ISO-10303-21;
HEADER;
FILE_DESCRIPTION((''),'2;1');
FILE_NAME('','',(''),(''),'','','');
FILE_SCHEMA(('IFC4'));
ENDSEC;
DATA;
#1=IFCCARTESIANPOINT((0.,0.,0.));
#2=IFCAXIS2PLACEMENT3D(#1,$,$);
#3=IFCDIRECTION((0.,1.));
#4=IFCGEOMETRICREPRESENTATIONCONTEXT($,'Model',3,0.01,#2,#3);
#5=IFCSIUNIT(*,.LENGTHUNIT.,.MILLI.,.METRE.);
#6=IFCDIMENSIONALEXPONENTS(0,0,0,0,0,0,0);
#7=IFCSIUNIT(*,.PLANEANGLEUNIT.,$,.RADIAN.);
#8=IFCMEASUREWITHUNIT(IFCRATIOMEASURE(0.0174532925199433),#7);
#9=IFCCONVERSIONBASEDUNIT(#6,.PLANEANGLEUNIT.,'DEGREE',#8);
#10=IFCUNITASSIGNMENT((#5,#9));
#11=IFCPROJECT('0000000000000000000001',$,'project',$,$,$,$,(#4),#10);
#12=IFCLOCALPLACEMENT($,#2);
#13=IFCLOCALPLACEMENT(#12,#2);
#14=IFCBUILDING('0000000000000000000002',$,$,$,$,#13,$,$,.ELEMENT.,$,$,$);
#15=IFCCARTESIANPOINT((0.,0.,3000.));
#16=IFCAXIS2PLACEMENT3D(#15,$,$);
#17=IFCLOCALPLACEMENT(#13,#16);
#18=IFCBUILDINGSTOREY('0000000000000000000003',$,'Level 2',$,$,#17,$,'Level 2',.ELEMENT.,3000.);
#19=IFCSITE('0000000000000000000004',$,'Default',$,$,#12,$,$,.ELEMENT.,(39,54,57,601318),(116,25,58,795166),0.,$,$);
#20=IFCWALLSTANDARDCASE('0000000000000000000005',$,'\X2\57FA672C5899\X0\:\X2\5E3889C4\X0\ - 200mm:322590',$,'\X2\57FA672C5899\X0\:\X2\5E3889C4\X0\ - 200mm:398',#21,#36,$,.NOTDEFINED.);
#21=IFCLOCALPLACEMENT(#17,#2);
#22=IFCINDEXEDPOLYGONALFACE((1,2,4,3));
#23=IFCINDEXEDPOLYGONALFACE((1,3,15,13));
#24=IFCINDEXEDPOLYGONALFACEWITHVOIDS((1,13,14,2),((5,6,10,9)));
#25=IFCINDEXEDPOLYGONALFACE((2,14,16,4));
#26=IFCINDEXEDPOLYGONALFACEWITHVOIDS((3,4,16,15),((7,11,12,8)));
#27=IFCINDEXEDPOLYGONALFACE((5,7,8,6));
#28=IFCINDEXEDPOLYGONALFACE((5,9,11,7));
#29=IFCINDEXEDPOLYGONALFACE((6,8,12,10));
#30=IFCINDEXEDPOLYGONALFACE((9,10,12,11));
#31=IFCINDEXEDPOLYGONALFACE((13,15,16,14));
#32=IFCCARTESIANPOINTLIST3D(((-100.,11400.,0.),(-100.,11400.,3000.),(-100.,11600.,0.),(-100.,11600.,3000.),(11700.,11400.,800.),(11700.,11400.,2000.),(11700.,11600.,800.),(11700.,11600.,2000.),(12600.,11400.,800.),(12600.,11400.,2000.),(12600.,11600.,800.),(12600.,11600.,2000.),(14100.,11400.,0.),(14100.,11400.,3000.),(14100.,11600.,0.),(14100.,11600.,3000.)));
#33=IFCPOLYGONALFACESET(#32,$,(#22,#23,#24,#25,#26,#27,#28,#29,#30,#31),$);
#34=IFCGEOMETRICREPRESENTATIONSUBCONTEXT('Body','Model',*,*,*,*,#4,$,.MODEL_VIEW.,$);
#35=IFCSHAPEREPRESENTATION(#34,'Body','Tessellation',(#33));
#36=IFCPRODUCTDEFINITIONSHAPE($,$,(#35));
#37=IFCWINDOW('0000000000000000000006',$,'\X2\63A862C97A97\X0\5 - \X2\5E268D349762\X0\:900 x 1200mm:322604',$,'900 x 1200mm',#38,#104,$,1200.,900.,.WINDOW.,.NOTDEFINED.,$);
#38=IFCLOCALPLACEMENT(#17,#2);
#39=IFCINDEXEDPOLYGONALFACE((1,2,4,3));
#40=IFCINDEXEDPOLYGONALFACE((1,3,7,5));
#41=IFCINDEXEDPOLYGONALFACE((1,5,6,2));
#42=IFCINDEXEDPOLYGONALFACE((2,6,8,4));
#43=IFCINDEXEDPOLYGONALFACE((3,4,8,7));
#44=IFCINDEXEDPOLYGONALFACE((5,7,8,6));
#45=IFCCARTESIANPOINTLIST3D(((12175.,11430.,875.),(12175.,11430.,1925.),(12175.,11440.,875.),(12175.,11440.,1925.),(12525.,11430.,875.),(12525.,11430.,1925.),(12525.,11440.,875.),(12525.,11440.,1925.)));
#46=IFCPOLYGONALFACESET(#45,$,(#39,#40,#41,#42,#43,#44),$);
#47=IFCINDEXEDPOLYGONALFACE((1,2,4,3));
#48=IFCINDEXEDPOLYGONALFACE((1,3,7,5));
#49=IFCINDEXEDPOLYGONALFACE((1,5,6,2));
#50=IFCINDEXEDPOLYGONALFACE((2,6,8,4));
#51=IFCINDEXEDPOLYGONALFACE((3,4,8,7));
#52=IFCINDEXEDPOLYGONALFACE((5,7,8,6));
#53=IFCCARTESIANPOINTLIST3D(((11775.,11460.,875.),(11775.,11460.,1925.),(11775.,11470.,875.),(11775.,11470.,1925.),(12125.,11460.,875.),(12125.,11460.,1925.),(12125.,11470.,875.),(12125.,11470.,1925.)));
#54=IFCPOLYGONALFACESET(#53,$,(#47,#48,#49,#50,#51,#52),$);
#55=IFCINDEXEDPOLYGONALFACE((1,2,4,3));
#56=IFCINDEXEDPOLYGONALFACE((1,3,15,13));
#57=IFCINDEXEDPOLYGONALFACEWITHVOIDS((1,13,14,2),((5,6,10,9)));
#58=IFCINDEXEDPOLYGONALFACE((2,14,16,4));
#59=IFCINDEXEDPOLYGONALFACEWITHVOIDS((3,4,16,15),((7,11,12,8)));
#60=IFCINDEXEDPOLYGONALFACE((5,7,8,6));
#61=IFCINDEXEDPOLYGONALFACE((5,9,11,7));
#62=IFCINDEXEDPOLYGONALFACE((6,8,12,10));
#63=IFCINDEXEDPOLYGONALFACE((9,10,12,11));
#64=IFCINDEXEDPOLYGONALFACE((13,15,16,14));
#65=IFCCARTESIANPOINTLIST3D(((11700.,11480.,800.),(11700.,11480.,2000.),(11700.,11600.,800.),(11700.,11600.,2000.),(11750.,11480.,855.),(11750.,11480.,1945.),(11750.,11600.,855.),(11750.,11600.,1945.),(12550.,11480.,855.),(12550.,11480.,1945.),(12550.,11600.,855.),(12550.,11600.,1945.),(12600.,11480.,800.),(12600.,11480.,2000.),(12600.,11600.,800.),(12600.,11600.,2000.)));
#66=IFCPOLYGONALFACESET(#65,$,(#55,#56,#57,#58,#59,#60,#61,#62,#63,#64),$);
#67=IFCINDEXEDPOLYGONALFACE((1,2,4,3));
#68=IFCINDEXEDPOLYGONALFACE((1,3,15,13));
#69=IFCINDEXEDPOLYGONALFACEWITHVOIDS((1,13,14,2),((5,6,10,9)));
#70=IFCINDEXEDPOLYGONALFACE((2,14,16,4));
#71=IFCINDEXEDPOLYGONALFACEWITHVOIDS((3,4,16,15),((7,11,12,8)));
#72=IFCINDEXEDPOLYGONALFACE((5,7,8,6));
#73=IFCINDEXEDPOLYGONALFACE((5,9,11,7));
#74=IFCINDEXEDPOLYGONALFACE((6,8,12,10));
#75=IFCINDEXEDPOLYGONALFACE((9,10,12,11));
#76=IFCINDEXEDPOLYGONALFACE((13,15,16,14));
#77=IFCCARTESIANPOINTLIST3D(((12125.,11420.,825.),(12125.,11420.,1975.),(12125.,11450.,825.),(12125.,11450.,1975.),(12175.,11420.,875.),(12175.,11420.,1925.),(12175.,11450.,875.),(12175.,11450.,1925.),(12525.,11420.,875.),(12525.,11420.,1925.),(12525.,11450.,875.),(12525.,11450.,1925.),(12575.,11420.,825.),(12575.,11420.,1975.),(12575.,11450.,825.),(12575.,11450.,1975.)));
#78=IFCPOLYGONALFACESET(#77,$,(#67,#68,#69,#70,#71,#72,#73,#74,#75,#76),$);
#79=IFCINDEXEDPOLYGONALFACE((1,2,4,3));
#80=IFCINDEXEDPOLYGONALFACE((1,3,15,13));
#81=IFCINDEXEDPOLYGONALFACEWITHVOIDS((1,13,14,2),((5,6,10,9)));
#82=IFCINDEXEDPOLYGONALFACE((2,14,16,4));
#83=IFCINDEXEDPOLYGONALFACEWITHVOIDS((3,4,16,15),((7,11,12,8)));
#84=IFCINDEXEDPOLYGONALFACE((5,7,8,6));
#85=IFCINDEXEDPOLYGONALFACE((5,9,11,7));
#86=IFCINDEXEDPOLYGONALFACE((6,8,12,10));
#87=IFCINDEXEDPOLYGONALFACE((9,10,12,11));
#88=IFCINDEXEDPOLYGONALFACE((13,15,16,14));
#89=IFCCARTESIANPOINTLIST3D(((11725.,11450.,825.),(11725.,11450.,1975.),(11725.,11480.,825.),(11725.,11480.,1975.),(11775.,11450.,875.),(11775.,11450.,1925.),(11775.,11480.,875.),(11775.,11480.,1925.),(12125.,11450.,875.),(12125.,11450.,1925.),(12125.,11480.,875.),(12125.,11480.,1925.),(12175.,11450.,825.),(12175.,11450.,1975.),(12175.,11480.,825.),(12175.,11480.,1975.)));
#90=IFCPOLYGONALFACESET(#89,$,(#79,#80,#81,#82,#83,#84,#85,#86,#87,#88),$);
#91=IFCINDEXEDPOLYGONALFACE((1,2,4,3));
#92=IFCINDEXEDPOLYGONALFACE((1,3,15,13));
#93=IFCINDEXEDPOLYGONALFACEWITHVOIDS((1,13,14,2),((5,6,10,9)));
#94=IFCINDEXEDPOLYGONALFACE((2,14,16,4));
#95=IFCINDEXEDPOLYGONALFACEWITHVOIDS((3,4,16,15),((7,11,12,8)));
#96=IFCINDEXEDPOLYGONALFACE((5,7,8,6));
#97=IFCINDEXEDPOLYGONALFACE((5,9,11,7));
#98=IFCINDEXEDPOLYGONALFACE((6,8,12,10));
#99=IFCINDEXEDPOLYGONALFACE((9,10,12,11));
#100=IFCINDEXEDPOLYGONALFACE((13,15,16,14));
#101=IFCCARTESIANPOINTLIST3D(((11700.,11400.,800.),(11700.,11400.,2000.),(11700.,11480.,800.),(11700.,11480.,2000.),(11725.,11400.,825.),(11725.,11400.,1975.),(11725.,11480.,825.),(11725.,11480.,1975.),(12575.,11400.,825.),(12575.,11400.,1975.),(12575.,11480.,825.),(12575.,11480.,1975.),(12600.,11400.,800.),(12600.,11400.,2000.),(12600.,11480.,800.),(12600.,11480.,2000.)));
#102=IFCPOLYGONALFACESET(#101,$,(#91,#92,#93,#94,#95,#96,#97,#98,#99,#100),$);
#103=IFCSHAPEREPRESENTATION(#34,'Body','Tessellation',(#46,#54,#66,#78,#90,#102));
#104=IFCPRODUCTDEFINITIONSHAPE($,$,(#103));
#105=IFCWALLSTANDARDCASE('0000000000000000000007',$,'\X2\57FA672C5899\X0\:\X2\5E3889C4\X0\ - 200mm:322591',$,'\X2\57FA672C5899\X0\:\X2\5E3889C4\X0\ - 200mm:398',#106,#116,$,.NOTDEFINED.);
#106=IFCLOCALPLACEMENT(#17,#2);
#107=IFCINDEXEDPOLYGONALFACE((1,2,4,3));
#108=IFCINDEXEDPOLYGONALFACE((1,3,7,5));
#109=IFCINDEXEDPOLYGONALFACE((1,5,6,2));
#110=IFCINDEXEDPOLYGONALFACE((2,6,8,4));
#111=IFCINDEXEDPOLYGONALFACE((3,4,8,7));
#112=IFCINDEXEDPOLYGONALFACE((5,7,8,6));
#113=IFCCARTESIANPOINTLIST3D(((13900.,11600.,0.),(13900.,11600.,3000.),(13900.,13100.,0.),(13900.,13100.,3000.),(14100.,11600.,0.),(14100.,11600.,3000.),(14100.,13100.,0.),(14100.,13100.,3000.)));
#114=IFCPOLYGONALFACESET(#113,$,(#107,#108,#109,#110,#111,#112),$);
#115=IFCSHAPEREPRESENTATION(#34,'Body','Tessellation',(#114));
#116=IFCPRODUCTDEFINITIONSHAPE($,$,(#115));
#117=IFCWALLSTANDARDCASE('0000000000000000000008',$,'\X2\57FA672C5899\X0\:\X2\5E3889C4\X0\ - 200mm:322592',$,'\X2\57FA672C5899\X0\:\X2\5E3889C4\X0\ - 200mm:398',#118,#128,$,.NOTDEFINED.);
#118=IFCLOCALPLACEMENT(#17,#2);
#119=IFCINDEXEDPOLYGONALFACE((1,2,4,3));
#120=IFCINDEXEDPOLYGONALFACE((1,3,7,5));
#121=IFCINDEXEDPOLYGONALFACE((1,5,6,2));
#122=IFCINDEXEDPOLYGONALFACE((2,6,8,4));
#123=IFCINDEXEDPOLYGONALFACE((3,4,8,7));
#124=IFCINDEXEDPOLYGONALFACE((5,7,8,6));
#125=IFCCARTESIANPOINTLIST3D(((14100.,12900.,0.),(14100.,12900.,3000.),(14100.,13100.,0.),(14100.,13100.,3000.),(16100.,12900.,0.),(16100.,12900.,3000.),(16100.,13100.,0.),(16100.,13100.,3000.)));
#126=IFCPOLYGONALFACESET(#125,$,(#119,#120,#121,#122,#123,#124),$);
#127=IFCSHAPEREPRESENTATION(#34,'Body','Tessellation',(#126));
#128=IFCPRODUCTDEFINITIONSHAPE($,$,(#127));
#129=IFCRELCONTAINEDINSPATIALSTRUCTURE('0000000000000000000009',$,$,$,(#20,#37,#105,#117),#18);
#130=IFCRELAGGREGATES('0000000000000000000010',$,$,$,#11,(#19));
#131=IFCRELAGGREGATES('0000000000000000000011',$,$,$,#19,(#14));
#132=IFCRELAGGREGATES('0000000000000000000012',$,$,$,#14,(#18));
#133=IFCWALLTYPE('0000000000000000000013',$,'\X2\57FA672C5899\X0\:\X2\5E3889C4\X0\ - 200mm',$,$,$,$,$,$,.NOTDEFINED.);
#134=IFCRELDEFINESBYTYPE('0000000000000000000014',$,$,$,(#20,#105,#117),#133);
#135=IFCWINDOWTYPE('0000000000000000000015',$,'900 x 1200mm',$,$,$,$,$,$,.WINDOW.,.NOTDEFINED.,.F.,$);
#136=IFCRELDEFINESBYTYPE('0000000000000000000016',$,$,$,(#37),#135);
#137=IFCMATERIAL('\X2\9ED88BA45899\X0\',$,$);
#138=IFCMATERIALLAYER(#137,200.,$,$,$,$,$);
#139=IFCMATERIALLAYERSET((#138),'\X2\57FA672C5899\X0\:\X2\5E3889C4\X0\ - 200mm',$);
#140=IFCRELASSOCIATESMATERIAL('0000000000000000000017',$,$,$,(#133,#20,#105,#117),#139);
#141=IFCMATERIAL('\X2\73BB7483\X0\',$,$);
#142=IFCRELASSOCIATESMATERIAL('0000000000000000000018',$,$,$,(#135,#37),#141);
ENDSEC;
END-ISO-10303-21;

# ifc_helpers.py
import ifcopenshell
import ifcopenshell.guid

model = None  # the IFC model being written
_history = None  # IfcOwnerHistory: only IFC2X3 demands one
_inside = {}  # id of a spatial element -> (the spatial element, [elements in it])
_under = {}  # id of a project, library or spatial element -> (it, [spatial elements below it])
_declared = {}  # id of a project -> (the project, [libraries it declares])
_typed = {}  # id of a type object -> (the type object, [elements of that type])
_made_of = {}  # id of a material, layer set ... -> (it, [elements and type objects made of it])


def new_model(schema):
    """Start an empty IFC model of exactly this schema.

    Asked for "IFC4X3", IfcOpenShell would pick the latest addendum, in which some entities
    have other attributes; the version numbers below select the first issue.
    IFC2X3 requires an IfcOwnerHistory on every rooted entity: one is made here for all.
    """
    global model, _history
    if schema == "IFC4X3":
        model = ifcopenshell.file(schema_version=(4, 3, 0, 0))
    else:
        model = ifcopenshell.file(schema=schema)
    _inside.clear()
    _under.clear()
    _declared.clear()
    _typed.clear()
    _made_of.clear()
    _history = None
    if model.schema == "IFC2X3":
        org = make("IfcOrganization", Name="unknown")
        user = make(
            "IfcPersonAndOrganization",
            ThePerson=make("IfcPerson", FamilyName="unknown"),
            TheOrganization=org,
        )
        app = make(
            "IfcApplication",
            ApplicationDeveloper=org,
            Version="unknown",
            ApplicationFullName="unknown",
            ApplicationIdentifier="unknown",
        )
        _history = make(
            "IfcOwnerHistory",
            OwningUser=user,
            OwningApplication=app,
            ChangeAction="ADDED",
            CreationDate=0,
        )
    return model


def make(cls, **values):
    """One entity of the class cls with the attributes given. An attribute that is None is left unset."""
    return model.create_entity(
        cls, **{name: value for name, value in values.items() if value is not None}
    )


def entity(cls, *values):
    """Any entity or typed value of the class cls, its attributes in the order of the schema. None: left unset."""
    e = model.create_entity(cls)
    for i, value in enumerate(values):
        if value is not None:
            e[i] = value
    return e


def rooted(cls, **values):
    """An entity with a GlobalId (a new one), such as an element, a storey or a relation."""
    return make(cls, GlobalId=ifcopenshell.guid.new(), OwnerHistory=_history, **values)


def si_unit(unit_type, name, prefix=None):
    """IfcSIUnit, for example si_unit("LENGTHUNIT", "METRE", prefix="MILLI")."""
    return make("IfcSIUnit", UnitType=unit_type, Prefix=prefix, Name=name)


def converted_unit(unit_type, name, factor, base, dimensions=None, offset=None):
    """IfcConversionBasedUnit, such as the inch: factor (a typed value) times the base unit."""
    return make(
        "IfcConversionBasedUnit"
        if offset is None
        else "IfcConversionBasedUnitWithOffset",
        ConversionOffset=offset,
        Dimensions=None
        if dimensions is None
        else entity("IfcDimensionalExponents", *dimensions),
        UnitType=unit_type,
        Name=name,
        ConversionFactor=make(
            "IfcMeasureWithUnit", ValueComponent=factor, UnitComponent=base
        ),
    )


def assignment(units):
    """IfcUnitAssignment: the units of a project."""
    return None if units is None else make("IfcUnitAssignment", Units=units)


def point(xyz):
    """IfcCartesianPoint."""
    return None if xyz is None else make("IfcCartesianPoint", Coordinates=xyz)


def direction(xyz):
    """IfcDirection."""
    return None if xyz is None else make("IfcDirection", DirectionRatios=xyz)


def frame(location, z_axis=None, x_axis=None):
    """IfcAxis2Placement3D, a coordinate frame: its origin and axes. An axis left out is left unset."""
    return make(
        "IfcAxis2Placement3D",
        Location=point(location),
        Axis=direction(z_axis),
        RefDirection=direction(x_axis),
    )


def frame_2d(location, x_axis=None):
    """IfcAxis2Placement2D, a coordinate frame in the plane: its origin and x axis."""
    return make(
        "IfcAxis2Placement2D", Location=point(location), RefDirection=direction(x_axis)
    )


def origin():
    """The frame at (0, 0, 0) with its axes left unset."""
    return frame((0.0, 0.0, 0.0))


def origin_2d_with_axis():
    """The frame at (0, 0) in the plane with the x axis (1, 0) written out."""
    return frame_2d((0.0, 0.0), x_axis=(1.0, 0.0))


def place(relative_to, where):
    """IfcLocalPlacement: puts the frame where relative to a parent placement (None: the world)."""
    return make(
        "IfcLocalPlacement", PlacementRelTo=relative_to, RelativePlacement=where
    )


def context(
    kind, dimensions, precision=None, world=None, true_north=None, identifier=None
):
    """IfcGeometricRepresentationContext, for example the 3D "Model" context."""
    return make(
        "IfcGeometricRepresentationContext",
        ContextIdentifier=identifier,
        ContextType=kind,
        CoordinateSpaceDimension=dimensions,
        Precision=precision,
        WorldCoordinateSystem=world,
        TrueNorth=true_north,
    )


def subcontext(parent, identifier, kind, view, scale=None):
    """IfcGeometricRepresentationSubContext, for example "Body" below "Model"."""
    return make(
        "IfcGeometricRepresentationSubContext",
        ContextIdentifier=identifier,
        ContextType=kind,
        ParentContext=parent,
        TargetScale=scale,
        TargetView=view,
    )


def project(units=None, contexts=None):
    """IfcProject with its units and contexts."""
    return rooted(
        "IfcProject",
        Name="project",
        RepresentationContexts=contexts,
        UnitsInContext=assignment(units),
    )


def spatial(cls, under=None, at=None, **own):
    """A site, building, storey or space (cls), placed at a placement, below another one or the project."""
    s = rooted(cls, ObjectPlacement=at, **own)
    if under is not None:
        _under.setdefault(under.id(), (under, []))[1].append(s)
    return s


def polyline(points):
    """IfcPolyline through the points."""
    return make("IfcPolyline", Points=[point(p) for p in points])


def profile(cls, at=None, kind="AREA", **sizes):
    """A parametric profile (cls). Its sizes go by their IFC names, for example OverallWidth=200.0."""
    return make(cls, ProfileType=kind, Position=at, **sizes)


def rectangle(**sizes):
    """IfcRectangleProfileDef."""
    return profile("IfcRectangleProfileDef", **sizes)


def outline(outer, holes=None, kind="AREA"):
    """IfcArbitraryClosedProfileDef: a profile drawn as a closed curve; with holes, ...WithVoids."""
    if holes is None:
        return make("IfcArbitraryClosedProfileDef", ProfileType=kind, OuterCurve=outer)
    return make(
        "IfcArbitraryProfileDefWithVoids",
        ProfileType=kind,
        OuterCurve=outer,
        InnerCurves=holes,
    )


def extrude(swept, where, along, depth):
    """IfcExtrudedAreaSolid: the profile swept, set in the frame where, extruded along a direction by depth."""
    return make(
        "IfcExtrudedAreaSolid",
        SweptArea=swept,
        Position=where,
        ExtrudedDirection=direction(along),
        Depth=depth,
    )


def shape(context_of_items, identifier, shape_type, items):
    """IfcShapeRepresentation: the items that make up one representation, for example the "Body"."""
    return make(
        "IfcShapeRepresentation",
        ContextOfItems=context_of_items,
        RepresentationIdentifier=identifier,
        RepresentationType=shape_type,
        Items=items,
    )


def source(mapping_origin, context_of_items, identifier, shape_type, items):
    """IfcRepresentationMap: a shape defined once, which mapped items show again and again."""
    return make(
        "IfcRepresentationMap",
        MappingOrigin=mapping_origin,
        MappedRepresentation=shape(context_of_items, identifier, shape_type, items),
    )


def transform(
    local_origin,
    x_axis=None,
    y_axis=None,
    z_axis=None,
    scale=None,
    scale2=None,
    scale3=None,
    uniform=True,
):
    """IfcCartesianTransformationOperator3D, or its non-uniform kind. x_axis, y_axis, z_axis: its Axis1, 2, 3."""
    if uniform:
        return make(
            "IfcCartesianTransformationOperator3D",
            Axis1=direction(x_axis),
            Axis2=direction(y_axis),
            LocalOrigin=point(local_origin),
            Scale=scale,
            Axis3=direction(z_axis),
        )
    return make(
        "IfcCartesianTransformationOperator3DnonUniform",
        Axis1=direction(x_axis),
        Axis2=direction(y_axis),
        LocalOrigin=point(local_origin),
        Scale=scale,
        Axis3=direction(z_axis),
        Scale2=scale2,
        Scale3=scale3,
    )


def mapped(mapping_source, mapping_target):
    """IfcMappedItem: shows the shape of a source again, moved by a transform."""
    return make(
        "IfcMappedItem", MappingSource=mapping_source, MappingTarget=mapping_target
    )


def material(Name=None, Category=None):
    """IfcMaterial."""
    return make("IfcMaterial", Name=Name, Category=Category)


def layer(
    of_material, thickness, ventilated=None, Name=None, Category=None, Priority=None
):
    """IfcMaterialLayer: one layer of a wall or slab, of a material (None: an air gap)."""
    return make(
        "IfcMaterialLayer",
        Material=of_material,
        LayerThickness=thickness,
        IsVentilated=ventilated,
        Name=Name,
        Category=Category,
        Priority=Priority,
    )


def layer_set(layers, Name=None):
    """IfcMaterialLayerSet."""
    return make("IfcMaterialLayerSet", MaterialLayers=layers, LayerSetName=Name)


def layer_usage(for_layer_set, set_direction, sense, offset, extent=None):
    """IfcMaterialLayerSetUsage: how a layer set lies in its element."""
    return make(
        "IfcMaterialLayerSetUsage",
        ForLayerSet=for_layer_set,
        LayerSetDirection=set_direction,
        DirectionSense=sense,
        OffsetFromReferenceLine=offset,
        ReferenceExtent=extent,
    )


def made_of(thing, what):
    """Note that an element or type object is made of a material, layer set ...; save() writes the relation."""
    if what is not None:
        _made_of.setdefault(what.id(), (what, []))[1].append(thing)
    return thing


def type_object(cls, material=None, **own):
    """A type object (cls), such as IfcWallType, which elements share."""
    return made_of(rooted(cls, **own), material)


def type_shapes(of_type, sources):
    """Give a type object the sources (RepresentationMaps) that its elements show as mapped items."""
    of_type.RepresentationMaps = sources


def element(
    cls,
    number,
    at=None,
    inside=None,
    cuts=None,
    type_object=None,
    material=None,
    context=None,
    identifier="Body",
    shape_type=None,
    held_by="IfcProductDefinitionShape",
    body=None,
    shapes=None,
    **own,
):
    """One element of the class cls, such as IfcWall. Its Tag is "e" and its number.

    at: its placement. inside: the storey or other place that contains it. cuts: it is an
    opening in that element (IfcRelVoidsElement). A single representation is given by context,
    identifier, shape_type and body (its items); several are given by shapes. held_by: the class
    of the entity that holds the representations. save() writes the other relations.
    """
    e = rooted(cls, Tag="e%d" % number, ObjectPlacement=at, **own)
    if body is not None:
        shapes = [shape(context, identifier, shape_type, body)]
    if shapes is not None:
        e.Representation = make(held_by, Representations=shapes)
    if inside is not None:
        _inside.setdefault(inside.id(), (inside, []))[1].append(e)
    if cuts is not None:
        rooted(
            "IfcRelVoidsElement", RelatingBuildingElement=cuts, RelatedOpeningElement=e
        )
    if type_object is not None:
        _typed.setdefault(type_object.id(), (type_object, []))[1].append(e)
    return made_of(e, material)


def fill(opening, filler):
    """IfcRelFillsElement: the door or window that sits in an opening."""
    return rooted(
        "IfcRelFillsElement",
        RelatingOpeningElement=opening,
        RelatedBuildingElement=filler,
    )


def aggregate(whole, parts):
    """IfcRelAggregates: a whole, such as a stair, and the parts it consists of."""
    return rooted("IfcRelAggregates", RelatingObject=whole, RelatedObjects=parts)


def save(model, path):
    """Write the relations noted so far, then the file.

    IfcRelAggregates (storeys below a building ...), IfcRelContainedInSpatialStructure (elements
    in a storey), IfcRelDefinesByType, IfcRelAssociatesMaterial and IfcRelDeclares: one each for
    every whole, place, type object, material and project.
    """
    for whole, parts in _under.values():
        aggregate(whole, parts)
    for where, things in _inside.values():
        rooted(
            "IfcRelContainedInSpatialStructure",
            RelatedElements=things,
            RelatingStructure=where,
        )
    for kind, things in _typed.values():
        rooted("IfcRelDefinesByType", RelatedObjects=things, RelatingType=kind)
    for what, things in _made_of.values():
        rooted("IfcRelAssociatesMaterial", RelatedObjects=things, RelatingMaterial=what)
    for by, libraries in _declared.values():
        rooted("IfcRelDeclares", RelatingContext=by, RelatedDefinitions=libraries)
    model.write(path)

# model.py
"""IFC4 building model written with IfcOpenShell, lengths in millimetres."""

from ifc_helpers import new_model, entity, si_unit, converted_unit, direction, frame, frame_2d, origin, origin_2d_with_axis, place, context, subcontext, project, spatial, polyline, rectangle, outline, extrude, source, transform, mapped, material, layer, layer_set, layer_usage, type_object, type_shapes, element, fill, save


model = new_model("IFC4")

# Units and contexts
model_context = context("Model", 3, precision=0.01, world=origin(), true_north=direction((0.0, 1.0)))
body_context = subcontext(model_context, "Body", "Model", "MODEL_VIEW")
ifc_project = project(units=[si_unit("LENGTHUNIT", "METRE", prefix="MILLI"), converted_unit("PLANEANGLEUNIT", "DEGREE", entity("IfcRatioMeasure", 0.0174532925199433), si_unit("PLANEANGLEUNIT", "RADIAN"), dimensions=[0, 0, 0, 0, 0, 0, 0])], contexts=[model_context])

# Site, building, storey
site_placement = place(None, origin())
site = spatial("IfcSite", under=ifc_project, at=site_placement, Name="Default", CompositionType="ELEMENT", RefLatitude=(39, 54, 57, 601318), RefLongitude=(116, 25, 58, 795166), RefElevation=0.0)
building_placement = place(site_placement, origin())
building = spatial("IfcBuilding", under=site, at=building_placement, CompositionType="ELEMENT")
storey_placement = place(building_placement, frame((0.0, 0.0, 3000.0)))
storey = spatial("IfcBuildingStorey", under=building, at=storey_placement, Name="Level 2", LongName="Level 2", CompositionType="ELEMENT", Elevation=3000.0)

# Shared definitions
ifc_material_1 = material(Name="默认墙")
ifc_layer_1 = layer(ifc_material_1, 200.0)
ifc_layer_set_1 = layer_set([ifc_layer_1], Name="基本墙:常规 - 200mm")
wall_type = type_object("IfcWallType", Name="基本墙:常规 - 200mm", PredefinedType="NOTDEFINED", material=ifc_layer_set_1)

# Wall, opening, window
ifc_layer_usage_1 = layer_usage(ifc_layer_set_1, "AXIS2", "NEGATIVE", 100.0)
wall_1_placement = place(storey_placement, frame((-100.0, 11500.0, 0.0)))
wall_1 = element("IfcWallStandardCase", 1, at=wall_1_placement, inside=storey, type_object=wall_type, material=ifc_layer_usage_1, Name="基本墙:常规 - 200mm:322590", ObjectType="基本墙:常规 - 200mm:398", PredefinedType="NOTDEFINED", context=body_context, shape_type="SweptSolid", body=[
    extrude(rectangle(XDim=14200.0, YDim=200.0, at=frame_2d((7100.0, 0.0), x_axis=(-1.0, 0.0))), origin(), (0.0, 0.0, 1.0), 3000.0),
])
opening_1_placement = place(wall_1_placement, frame((12700.0, 100.0, 800.0)))
opening_1 = element("IfcOpeningElement", 2, at=opening_1_placement, cuts=wall_1, ObjectType="Opening", PredefinedType="OPENING", context=body_context, shape_type="SweptSolid", body=[
    extrude(rectangle(XDim=1200.0, YDim=900.0, at=frame_2d((600.0, 450.0), x_axis=(-1.0, 0.0))), frame((0.0, 0.0, 0.0), z_axis=(0.0, -1.0, 0.0), x_axis=(0.0, 0.0, 1.0)), (0.0, 0.0, 1.0), 200.0),
])
ifc_material_2 = material(Name="玻璃")
window_type_1 = type_object("IfcWindowType", Name="900 x 1200mm", ParameterTakesPrecedence=False, PartitioningType="NOTDEFINED", PredefinedType="WINDOW", material=ifc_material_2)
shared_shape_1 = source(origin(), body_context, "Body", "SweptSolid", [
    extrude(rectangle(XDim=10.0, YDim=350.0, at=origin_2d_with_axis()), frame((250.0, 165.0, 75.0), z_axis=(0.0, 0.0, 1.0), x_axis=(0.0, -1.0, 0.0)), (0.0, 0.0, 1.0), 1050.0),
    extrude(rectangle(XDim=10.0, YDim=350.0, at=frame_2d((0.0, 0.0), x_axis=(1.0, 0.0))), frame((650.0, 135.0, 75.0), z_axis=(0.0, 0.0, 1.0), x_axis=(0.0, -1.0, 0.0)), (0.0, 0.0, 1.0), 1050.0),
    extrude(outline(polyline([(-450.0, -600.0), (450.0, -600.0), (450.0, 600.0), (-450.0, 600.0), (-450.0, -600.0)]), holes=[polyline([(400.0, -545.0), (-400.0, -545.0), (-400.0, 545.0), (400.0, 545.0), (400.0, -545.0)])]), frame((450.0, 0.0, 600.0), z_axis=(0.0, 1.0, 0.0), x_axis=(1.0, 0.0, 0.0)), (0.0, 0.0, 1.0), 120.0),
    extrude(outline(polyline([(-225.0, -575.0), (225.0, -575.0), (225.0, 575.0), (-225.0, 575.0), (-225.0, -575.0)]), holes=[polyline([(-175.0, -525.0), (-175.0, 525.0), (175.0, 525.0), (175.0, -525.0), (-175.0, -525.0)])]), frame((250.0, 150.0, 600.0), z_axis=(0.0, 1.0, 0.0), x_axis=(-1.0, 0.0, 0.0)), (0.0, 0.0, 1.0), 30.0),
    extrude(outline(polyline([(-225.0, -575.0), (225.0, -575.0), (225.0, 575.0), (-225.0, 575.0), (-225.0, -575.0)]), holes=[polyline([(-175.0, -525.0), (-175.0, 525.0), (175.0, 525.0), (175.0, -525.0), (-175.0, -525.0)])]), frame((650.0, 120.0, 600.0), z_axis=(0.0, 1.0, 0.0), x_axis=(1.0, 0.0, 0.0)), (0.0, 0.0, 1.0), 30.0),
    extrude(outline(polyline([(-450.0, -600.0), (450.0, -600.0), (450.0, 600.0), (-450.0, 600.0), (-450.0, -600.0)]), holes=[polyline([(-425.0, 575.0), (425.0, 575.0), (425.0, -575.0), (-425.0, -575.0), (-425.0, 575.0)])]), frame((450.0, 120.0, 600.0), z_axis=(0.0, 1.0, 0.0), x_axis=(1.0, 0.0, 0.0)), (0.0, 0.0, 1.0), 80.0),
])
type_shapes(window_type_1, [shared_shape_1])
window_1_placement = place(opening_1_placement, frame((0.0, 0.0, 0.0), z_axis=(0.0, 0.0, 1.0), x_axis=(-1.0, 0.0, 0.0)))
window_1 = element("IfcWindow", 3, at=window_1_placement, inside=storey, type_object=window_type_1, material=ifc_material_2, Name="推拉窗5 - 带贴面:900 x 1200mm:322604", ObjectType="900 x 1200mm", OverallHeight=1200.0, OverallWidth=900.0, PartitioningType="NOTDEFINED", PredefinedType="WINDOW", context=body_context, shape_type="MappedRepresentation", body=[
    mapped(shared_shape_1, transform((0.0, 0.0, 0.0), scale=1.0)),
])
fill(opening_1, window_1)

# Walls
ifc_layer_usage_2 = layer_usage(ifc_layer_set_1, "AXIS2", "NEGATIVE", 100.0)
wall_2_placement = place(storey_placement, frame((14000.0, 11600.0, 0.0), z_axis=(0.0, 0.0, 1.0), x_axis=(0.0, 1.0, 0.0)))
element("IfcWallStandardCase", 4, at=wall_2_placement, inside=storey, type_object=wall_type, material=ifc_layer_usage_2, Name="基本墙:常规 - 200mm:322591", ObjectType="基本墙:常规 - 200mm:398", PredefinedType="NOTDEFINED", context=body_context, shape_type="SweptSolid", body=[
    extrude(rectangle(XDim=1500.0, YDim=200.0, at=frame_2d((750.0, 0.0), x_axis=(-1.0, 0.0))), origin(), (0.0, 0.0, 1.0), 3000.0),
])
ifc_layer_usage_3 = layer_usage(ifc_layer_set_1, "AXIS2", "NEGATIVE", 100.0)
wall_3_placement = place(storey_placement, frame((14100.0, 13000.0, 0.0)))
element("IfcWallStandardCase", 5, at=wall_3_placement, inside=storey, type_object=wall_type, material=ifc_layer_usage_3, Name="基本墙:常规 - 200mm:322592", ObjectType="基本墙:常规 - 200mm:398", PredefinedType="NOTDEFINED", context=body_context, shape_type="SweptSolid", body=[
    extrude(rectangle(XDim=2000.0, YDim=200.0, at=frame_2d((1000.0, 0.0), x_axis=(-1.0, 0.0))), origin(), (0.0, 0.0, 1.0), 3000.0),
])

save(model, "model.ifc")
